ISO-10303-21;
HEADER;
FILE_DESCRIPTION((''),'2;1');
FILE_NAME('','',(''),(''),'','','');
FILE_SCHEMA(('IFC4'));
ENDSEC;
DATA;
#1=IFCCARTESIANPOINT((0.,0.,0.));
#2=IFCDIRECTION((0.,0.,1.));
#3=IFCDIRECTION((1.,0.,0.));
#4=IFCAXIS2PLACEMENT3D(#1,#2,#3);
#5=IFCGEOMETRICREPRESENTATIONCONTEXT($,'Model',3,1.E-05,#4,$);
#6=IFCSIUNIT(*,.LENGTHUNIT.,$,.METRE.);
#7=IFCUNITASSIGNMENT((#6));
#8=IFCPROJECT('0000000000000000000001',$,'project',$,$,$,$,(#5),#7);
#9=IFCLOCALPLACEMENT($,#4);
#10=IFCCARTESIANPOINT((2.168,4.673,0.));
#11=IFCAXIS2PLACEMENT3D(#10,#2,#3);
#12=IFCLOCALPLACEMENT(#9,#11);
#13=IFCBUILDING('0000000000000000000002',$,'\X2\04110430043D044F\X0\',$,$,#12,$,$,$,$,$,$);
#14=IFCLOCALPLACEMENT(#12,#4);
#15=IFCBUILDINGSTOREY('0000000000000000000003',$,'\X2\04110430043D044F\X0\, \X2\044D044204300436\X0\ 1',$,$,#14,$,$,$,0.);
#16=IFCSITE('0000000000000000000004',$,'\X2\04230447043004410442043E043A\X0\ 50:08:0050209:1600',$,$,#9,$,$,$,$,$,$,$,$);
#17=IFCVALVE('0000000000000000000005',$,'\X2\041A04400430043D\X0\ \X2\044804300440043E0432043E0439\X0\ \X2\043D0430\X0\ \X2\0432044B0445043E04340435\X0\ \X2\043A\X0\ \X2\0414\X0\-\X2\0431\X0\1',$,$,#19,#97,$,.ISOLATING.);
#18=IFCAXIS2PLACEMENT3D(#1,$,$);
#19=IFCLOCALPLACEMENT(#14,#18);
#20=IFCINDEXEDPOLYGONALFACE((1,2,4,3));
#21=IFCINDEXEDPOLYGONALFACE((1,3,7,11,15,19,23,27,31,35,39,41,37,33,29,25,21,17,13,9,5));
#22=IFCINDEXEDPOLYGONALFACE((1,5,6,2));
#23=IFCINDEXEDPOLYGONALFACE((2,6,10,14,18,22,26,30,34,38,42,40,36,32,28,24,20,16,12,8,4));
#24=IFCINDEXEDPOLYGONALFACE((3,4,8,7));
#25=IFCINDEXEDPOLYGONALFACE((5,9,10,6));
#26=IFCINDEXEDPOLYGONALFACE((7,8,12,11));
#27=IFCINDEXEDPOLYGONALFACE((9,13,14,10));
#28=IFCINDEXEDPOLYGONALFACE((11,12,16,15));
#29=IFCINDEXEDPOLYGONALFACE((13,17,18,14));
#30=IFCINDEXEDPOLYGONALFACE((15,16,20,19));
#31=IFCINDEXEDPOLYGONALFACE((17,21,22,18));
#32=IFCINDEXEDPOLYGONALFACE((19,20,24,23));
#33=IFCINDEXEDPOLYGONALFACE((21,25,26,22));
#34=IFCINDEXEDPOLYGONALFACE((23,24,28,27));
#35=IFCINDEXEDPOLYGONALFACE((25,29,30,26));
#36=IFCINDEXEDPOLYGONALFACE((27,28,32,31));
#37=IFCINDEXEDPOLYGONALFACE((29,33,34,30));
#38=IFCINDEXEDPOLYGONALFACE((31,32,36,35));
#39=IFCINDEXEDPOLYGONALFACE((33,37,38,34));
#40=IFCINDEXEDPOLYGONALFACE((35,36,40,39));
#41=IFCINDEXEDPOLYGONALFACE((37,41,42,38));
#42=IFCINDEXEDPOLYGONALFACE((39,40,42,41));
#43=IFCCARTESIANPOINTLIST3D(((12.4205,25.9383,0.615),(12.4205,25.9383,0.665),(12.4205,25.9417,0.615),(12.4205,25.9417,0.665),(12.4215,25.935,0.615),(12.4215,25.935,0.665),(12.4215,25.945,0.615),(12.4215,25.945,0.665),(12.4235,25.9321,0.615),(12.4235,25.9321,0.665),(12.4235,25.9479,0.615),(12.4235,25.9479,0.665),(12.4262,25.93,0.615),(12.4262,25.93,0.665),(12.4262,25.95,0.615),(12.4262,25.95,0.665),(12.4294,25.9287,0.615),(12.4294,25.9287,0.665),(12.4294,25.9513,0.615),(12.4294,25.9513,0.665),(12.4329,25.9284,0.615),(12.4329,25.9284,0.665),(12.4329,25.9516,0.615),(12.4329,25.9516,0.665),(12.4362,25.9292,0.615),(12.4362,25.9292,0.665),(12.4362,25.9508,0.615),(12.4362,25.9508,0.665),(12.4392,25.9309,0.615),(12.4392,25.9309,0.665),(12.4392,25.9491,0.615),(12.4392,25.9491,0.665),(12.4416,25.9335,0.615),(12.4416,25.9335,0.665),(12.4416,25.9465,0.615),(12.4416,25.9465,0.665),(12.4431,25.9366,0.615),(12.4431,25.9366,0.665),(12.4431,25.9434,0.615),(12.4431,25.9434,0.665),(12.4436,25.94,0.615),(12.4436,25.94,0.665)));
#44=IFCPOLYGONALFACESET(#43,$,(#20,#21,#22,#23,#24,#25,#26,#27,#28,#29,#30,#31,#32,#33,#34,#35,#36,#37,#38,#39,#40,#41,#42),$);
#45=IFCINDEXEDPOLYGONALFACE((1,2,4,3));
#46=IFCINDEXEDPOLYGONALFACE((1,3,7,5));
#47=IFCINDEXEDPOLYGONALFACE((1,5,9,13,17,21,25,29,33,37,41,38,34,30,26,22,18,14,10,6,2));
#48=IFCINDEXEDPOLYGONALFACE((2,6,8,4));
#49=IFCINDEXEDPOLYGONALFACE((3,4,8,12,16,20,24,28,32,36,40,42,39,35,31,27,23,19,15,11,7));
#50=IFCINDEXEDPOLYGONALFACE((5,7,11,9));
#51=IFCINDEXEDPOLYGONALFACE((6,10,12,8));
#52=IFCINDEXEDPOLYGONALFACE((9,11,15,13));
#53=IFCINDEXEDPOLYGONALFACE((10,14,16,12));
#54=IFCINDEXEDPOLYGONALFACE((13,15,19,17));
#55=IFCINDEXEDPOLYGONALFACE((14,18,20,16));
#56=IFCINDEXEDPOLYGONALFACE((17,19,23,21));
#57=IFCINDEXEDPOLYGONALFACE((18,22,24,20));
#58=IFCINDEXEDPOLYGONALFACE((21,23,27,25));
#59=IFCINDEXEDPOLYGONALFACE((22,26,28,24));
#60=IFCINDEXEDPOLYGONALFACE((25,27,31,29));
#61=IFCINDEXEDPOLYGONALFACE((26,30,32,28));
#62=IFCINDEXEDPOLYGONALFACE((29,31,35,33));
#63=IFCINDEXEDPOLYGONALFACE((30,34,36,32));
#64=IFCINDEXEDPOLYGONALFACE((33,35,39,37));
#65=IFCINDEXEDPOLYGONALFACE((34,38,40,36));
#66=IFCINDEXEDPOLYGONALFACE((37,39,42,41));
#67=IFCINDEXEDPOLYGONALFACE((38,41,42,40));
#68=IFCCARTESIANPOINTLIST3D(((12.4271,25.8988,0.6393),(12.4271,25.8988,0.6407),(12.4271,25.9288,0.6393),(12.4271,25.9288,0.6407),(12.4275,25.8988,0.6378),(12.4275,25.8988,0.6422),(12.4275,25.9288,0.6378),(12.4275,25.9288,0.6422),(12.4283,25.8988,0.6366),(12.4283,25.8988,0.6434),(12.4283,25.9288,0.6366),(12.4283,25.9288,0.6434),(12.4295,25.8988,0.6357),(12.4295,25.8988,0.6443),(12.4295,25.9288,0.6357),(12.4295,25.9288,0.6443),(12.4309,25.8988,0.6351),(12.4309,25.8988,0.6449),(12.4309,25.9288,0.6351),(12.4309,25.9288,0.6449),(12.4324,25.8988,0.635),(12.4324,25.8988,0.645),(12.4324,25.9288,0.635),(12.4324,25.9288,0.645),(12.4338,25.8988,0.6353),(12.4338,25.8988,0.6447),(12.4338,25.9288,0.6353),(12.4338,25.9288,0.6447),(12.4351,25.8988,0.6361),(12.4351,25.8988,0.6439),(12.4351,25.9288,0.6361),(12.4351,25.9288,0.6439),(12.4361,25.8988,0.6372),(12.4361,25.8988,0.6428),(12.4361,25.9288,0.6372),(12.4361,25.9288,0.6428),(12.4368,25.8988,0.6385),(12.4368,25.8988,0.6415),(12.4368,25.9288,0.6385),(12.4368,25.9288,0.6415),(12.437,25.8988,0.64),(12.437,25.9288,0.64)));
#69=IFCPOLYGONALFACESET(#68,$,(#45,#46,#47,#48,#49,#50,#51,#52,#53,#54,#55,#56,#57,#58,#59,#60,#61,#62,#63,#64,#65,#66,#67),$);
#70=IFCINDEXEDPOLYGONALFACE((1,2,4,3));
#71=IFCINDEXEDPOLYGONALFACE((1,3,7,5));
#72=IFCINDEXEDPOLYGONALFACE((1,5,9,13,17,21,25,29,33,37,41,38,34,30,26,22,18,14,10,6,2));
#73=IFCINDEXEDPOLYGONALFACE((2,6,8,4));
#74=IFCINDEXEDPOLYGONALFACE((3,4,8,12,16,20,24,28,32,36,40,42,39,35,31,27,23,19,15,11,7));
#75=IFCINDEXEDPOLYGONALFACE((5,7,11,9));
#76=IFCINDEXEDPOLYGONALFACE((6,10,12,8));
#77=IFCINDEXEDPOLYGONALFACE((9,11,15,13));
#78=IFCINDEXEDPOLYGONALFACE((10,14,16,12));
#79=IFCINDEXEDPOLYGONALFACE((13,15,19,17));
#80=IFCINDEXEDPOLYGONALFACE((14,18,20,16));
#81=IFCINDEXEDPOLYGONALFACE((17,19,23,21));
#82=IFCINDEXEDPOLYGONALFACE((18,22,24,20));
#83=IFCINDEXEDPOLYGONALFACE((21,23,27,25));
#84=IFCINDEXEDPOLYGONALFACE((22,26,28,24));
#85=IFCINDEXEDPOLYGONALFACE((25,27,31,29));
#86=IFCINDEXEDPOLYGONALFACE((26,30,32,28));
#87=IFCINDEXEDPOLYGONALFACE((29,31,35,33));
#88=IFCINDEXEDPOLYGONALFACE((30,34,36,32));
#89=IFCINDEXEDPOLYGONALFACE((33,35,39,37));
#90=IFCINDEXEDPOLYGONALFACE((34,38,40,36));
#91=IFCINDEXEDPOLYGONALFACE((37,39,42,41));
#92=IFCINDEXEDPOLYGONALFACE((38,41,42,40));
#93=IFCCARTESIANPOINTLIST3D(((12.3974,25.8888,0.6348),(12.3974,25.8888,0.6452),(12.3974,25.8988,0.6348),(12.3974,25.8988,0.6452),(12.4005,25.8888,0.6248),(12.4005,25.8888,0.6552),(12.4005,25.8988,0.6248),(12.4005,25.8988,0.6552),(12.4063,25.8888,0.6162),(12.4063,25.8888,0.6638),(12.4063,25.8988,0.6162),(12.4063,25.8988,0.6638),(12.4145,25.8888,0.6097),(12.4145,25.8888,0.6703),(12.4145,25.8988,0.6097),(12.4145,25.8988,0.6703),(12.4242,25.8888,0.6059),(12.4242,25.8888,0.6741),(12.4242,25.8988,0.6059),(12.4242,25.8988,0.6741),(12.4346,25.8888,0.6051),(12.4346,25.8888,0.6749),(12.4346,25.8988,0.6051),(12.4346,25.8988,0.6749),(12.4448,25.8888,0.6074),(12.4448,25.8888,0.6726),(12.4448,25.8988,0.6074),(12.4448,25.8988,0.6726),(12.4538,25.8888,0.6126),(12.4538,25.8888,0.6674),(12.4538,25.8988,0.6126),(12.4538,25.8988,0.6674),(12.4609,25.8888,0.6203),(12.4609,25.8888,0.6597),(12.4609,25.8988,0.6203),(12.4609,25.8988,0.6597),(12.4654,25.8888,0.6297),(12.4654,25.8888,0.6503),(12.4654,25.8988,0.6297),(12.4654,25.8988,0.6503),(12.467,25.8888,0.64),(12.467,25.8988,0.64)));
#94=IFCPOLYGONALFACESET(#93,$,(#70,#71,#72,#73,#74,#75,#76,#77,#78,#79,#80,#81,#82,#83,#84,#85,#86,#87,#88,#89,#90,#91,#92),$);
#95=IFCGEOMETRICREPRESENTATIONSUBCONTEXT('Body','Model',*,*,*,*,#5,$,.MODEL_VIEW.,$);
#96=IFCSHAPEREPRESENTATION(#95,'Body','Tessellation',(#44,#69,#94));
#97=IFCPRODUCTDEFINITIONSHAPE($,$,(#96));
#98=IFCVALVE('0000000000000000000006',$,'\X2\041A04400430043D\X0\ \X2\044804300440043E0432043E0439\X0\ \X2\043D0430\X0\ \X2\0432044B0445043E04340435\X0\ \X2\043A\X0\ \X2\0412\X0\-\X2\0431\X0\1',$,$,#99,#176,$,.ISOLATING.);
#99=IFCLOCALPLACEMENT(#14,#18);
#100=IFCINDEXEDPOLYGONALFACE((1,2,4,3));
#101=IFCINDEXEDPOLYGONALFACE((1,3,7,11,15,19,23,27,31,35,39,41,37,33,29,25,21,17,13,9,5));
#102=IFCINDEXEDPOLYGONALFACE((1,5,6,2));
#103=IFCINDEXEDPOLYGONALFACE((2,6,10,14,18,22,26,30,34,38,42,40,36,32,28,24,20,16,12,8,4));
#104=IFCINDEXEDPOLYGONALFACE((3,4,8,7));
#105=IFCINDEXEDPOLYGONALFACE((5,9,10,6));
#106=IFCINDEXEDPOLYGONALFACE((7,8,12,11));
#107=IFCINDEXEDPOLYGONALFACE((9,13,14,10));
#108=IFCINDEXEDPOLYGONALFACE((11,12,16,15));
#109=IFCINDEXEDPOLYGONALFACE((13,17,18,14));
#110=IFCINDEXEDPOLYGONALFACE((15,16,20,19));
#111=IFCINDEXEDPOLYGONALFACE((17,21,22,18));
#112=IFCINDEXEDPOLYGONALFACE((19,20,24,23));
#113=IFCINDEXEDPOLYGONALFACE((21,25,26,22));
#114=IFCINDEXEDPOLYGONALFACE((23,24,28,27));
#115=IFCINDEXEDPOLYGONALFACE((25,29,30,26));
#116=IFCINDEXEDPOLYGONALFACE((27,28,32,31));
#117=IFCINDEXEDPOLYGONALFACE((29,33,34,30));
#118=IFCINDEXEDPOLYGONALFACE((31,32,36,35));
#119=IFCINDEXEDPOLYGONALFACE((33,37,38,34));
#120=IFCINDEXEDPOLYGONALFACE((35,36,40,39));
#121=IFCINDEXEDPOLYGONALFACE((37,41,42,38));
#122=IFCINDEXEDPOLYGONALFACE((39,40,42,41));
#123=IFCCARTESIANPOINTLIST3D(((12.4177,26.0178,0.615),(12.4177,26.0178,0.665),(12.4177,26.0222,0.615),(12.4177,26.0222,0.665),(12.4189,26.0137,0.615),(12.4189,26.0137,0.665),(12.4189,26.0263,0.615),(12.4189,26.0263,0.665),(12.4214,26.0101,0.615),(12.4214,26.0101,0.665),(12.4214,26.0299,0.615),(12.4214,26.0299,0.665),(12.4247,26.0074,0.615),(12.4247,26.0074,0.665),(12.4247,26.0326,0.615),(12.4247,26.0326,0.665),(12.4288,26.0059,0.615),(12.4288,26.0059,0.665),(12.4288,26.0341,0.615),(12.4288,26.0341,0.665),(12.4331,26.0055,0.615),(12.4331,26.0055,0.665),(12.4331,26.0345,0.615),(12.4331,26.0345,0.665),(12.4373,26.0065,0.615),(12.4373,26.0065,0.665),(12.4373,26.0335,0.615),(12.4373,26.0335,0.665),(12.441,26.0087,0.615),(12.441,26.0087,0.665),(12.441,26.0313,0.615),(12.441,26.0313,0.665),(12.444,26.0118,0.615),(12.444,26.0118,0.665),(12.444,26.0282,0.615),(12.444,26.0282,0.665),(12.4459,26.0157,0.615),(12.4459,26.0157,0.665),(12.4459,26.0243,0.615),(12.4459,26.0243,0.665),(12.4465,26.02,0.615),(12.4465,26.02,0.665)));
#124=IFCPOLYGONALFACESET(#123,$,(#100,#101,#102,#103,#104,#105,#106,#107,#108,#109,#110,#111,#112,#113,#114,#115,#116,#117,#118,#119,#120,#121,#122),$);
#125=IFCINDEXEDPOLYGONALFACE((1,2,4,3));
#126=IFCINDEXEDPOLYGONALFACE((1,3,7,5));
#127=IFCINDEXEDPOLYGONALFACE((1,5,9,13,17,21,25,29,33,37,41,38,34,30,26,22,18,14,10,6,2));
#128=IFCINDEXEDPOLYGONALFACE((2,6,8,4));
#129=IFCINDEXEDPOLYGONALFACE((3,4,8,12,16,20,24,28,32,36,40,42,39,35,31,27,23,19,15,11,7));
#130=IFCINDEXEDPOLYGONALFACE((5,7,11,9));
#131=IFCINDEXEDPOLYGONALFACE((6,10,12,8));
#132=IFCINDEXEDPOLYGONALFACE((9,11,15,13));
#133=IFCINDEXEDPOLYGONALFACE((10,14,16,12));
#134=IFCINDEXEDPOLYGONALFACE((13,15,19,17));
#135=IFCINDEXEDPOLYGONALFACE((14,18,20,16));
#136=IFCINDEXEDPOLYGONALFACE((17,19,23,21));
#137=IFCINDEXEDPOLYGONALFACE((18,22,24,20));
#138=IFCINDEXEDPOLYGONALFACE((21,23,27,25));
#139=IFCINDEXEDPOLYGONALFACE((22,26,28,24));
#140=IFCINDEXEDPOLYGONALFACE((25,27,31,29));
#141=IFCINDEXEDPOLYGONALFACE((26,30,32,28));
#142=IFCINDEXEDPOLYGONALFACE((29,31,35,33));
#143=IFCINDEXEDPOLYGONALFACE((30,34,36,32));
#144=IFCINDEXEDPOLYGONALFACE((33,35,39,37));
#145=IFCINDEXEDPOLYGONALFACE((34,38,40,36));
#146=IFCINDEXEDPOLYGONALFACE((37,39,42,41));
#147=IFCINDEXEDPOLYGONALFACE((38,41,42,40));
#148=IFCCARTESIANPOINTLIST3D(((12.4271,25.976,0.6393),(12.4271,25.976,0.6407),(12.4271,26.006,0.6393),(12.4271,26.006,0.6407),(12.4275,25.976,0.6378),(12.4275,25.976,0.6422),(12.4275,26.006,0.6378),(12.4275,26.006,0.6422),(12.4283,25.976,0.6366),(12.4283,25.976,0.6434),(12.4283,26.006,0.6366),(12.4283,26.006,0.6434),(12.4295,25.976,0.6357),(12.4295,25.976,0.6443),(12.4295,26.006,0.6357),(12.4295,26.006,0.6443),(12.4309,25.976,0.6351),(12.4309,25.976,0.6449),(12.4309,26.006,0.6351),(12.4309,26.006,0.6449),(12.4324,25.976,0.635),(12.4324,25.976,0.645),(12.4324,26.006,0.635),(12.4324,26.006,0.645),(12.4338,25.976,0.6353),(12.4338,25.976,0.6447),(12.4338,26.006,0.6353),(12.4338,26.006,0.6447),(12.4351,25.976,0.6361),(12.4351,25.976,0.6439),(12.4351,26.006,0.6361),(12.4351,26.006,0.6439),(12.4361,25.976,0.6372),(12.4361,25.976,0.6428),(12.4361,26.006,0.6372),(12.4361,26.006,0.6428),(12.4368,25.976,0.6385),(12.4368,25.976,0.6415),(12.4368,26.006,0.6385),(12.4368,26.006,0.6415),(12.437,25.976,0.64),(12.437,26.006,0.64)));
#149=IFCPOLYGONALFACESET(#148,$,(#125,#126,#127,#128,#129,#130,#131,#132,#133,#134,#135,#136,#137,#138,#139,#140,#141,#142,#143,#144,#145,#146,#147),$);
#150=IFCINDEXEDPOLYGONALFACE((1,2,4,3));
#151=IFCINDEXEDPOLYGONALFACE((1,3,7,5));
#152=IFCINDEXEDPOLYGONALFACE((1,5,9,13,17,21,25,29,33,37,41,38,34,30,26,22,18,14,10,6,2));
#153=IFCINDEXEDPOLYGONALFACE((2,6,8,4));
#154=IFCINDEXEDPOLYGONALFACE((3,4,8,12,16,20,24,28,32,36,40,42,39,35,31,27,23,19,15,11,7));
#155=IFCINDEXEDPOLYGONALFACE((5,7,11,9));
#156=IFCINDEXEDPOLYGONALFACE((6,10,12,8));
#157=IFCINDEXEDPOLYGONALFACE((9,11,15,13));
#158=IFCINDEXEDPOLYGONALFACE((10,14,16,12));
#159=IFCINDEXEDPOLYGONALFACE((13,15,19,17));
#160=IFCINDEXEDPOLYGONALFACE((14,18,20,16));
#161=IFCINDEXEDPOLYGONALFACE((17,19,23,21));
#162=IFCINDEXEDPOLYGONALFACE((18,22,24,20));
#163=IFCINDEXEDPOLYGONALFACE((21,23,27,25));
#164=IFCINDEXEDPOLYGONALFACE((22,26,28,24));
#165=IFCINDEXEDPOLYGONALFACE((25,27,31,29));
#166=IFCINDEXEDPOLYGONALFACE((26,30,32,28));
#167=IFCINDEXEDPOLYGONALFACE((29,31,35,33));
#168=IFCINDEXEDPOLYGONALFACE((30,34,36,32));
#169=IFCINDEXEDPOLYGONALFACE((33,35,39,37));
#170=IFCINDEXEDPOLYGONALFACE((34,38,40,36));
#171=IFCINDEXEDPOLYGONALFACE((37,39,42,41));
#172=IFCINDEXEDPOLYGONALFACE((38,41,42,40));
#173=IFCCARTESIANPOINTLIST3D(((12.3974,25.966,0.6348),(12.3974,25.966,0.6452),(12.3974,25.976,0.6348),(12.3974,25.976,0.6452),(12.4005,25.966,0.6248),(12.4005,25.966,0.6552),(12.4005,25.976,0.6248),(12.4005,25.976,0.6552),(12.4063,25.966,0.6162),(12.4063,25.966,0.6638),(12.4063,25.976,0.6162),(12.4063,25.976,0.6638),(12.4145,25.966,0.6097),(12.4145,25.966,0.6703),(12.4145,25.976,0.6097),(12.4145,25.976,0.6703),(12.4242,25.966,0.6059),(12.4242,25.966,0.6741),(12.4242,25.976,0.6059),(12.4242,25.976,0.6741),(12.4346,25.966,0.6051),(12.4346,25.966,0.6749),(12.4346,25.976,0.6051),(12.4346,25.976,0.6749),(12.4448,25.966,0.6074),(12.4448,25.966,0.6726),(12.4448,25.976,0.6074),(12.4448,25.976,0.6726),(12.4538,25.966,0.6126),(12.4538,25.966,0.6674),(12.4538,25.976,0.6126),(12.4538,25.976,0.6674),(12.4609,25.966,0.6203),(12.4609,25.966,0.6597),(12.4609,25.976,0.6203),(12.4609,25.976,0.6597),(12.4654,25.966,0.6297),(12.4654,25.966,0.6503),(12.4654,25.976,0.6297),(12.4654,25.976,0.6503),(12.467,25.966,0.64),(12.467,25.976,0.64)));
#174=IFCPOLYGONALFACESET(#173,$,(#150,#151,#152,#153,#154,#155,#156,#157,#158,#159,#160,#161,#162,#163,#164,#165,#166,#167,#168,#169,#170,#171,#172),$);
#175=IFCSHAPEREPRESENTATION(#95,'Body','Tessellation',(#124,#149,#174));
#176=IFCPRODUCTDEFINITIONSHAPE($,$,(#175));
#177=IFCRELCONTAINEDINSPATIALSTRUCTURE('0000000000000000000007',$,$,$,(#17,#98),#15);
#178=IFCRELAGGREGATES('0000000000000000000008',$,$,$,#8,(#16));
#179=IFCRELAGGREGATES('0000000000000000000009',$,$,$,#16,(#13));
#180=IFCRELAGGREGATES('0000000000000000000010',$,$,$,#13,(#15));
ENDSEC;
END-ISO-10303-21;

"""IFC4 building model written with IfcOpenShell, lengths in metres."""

from ifc_helpers import new_model, si_unit, frame, origin_with_axes, origin_2d, place, context, subcontext, project, spatial, circle, extrude, element, save


model = new_model("IFC4")

# Units and contexts
model_context = context("Model", 3, precision=1e-05, world=origin_with_axes())
body_context = subcontext(model_context, "Body", "Model", "MODEL_VIEW")
ifc_project = project(units=[si_unit("LENGTHUNIT", "METRE")], contexts=[model_context])

# Site, building, storey
site_placement = place(None, origin_with_axes())
site = spatial("IfcSite", under=ifc_project, at=site_placement, Name="Участок 50:08:0050209:1600")
building_placement = place(site_placement, frame((2.168, 4.673, 0.0), z_axis=(0.0, 0.0, 1.0), x_axis=(1.0, 0.0, 0.0)))
building = spatial("IfcBuilding", under=site, at=building_placement, Name="Баня")
storey_placement = place(building_placement, origin_with_axes())
storey = spatial("IfcBuildingStorey", under=building, at=storey_placement, Name="Баня, этаж 1", Elevation=0.0)

# Valves
valve_1_placement = place(storey_placement, origin_with_axes())
element("IfcValve", 1, at=valve_1_placement, inside=storey, Name="Кран шаровой на выходе к Д-б1", PredefinedType="ISOLATING", context=body_context, shape_type="SweptSolid", body=[
    extrude(circle(Radius=0.0116, at=origin_2d()), frame((12.432, 25.94, 0.615), z_axis=(0.0, 0.0, 1.0), x_axis=(1.0, 0.0, 0.0)), (0.0, 0.0, 1.0), 0.05),
    extrude(circle(Radius=0.005, at=origin_2d()), frame((12.432, 25.9288, 0.64), z_axis=(0.0, -1.0, 0.0), x_axis=(1.0, 0.0, 0.0)), (0.0, 0.0, 1.0), 0.03),
    extrude(circle(Radius=0.035, at=origin_2d()), frame((12.432, 25.8988, 0.64), z_axis=(0.0, -1.0, 0.0), x_axis=(1.0, 0.0, 0.0)), (0.0, 0.0, 1.0), 0.01),
])
valve_2_placement = place(storey_placement, origin_with_axes())
element("IfcValve", 2, at=valve_2_placement, inside=storey, Name="Кран шаровой на выходе к В-б1", PredefinedType="ISOLATING", context=body_context, shape_type="SweptSolid", body=[
    extrude(circle(Radius=0.0145, at=origin_2d()), frame((12.432, 26.02, 0.615), z_axis=(0.0, 0.0, 1.0), x_axis=(1.0, 0.0, 0.0)), (0.0, 0.0, 1.0), 0.05),
    extrude(circle(Radius=0.005, at=origin_2d()), frame((12.432, 26.006, 0.64), z_axis=(0.0, -1.0, 0.0), x_axis=(1.0, 0.0, 0.0)), (0.0, 0.0, 1.0), 0.03),
    extrude(circle(Radius=0.035, at=origin_2d()), frame((12.432, 25.976, 0.64), z_axis=(0.0, -1.0, 0.0), x_axis=(1.0, 0.0, 0.0)), (0.0, 0.0, 1.0), 0.01),
])

save(model, "model.ifc")
